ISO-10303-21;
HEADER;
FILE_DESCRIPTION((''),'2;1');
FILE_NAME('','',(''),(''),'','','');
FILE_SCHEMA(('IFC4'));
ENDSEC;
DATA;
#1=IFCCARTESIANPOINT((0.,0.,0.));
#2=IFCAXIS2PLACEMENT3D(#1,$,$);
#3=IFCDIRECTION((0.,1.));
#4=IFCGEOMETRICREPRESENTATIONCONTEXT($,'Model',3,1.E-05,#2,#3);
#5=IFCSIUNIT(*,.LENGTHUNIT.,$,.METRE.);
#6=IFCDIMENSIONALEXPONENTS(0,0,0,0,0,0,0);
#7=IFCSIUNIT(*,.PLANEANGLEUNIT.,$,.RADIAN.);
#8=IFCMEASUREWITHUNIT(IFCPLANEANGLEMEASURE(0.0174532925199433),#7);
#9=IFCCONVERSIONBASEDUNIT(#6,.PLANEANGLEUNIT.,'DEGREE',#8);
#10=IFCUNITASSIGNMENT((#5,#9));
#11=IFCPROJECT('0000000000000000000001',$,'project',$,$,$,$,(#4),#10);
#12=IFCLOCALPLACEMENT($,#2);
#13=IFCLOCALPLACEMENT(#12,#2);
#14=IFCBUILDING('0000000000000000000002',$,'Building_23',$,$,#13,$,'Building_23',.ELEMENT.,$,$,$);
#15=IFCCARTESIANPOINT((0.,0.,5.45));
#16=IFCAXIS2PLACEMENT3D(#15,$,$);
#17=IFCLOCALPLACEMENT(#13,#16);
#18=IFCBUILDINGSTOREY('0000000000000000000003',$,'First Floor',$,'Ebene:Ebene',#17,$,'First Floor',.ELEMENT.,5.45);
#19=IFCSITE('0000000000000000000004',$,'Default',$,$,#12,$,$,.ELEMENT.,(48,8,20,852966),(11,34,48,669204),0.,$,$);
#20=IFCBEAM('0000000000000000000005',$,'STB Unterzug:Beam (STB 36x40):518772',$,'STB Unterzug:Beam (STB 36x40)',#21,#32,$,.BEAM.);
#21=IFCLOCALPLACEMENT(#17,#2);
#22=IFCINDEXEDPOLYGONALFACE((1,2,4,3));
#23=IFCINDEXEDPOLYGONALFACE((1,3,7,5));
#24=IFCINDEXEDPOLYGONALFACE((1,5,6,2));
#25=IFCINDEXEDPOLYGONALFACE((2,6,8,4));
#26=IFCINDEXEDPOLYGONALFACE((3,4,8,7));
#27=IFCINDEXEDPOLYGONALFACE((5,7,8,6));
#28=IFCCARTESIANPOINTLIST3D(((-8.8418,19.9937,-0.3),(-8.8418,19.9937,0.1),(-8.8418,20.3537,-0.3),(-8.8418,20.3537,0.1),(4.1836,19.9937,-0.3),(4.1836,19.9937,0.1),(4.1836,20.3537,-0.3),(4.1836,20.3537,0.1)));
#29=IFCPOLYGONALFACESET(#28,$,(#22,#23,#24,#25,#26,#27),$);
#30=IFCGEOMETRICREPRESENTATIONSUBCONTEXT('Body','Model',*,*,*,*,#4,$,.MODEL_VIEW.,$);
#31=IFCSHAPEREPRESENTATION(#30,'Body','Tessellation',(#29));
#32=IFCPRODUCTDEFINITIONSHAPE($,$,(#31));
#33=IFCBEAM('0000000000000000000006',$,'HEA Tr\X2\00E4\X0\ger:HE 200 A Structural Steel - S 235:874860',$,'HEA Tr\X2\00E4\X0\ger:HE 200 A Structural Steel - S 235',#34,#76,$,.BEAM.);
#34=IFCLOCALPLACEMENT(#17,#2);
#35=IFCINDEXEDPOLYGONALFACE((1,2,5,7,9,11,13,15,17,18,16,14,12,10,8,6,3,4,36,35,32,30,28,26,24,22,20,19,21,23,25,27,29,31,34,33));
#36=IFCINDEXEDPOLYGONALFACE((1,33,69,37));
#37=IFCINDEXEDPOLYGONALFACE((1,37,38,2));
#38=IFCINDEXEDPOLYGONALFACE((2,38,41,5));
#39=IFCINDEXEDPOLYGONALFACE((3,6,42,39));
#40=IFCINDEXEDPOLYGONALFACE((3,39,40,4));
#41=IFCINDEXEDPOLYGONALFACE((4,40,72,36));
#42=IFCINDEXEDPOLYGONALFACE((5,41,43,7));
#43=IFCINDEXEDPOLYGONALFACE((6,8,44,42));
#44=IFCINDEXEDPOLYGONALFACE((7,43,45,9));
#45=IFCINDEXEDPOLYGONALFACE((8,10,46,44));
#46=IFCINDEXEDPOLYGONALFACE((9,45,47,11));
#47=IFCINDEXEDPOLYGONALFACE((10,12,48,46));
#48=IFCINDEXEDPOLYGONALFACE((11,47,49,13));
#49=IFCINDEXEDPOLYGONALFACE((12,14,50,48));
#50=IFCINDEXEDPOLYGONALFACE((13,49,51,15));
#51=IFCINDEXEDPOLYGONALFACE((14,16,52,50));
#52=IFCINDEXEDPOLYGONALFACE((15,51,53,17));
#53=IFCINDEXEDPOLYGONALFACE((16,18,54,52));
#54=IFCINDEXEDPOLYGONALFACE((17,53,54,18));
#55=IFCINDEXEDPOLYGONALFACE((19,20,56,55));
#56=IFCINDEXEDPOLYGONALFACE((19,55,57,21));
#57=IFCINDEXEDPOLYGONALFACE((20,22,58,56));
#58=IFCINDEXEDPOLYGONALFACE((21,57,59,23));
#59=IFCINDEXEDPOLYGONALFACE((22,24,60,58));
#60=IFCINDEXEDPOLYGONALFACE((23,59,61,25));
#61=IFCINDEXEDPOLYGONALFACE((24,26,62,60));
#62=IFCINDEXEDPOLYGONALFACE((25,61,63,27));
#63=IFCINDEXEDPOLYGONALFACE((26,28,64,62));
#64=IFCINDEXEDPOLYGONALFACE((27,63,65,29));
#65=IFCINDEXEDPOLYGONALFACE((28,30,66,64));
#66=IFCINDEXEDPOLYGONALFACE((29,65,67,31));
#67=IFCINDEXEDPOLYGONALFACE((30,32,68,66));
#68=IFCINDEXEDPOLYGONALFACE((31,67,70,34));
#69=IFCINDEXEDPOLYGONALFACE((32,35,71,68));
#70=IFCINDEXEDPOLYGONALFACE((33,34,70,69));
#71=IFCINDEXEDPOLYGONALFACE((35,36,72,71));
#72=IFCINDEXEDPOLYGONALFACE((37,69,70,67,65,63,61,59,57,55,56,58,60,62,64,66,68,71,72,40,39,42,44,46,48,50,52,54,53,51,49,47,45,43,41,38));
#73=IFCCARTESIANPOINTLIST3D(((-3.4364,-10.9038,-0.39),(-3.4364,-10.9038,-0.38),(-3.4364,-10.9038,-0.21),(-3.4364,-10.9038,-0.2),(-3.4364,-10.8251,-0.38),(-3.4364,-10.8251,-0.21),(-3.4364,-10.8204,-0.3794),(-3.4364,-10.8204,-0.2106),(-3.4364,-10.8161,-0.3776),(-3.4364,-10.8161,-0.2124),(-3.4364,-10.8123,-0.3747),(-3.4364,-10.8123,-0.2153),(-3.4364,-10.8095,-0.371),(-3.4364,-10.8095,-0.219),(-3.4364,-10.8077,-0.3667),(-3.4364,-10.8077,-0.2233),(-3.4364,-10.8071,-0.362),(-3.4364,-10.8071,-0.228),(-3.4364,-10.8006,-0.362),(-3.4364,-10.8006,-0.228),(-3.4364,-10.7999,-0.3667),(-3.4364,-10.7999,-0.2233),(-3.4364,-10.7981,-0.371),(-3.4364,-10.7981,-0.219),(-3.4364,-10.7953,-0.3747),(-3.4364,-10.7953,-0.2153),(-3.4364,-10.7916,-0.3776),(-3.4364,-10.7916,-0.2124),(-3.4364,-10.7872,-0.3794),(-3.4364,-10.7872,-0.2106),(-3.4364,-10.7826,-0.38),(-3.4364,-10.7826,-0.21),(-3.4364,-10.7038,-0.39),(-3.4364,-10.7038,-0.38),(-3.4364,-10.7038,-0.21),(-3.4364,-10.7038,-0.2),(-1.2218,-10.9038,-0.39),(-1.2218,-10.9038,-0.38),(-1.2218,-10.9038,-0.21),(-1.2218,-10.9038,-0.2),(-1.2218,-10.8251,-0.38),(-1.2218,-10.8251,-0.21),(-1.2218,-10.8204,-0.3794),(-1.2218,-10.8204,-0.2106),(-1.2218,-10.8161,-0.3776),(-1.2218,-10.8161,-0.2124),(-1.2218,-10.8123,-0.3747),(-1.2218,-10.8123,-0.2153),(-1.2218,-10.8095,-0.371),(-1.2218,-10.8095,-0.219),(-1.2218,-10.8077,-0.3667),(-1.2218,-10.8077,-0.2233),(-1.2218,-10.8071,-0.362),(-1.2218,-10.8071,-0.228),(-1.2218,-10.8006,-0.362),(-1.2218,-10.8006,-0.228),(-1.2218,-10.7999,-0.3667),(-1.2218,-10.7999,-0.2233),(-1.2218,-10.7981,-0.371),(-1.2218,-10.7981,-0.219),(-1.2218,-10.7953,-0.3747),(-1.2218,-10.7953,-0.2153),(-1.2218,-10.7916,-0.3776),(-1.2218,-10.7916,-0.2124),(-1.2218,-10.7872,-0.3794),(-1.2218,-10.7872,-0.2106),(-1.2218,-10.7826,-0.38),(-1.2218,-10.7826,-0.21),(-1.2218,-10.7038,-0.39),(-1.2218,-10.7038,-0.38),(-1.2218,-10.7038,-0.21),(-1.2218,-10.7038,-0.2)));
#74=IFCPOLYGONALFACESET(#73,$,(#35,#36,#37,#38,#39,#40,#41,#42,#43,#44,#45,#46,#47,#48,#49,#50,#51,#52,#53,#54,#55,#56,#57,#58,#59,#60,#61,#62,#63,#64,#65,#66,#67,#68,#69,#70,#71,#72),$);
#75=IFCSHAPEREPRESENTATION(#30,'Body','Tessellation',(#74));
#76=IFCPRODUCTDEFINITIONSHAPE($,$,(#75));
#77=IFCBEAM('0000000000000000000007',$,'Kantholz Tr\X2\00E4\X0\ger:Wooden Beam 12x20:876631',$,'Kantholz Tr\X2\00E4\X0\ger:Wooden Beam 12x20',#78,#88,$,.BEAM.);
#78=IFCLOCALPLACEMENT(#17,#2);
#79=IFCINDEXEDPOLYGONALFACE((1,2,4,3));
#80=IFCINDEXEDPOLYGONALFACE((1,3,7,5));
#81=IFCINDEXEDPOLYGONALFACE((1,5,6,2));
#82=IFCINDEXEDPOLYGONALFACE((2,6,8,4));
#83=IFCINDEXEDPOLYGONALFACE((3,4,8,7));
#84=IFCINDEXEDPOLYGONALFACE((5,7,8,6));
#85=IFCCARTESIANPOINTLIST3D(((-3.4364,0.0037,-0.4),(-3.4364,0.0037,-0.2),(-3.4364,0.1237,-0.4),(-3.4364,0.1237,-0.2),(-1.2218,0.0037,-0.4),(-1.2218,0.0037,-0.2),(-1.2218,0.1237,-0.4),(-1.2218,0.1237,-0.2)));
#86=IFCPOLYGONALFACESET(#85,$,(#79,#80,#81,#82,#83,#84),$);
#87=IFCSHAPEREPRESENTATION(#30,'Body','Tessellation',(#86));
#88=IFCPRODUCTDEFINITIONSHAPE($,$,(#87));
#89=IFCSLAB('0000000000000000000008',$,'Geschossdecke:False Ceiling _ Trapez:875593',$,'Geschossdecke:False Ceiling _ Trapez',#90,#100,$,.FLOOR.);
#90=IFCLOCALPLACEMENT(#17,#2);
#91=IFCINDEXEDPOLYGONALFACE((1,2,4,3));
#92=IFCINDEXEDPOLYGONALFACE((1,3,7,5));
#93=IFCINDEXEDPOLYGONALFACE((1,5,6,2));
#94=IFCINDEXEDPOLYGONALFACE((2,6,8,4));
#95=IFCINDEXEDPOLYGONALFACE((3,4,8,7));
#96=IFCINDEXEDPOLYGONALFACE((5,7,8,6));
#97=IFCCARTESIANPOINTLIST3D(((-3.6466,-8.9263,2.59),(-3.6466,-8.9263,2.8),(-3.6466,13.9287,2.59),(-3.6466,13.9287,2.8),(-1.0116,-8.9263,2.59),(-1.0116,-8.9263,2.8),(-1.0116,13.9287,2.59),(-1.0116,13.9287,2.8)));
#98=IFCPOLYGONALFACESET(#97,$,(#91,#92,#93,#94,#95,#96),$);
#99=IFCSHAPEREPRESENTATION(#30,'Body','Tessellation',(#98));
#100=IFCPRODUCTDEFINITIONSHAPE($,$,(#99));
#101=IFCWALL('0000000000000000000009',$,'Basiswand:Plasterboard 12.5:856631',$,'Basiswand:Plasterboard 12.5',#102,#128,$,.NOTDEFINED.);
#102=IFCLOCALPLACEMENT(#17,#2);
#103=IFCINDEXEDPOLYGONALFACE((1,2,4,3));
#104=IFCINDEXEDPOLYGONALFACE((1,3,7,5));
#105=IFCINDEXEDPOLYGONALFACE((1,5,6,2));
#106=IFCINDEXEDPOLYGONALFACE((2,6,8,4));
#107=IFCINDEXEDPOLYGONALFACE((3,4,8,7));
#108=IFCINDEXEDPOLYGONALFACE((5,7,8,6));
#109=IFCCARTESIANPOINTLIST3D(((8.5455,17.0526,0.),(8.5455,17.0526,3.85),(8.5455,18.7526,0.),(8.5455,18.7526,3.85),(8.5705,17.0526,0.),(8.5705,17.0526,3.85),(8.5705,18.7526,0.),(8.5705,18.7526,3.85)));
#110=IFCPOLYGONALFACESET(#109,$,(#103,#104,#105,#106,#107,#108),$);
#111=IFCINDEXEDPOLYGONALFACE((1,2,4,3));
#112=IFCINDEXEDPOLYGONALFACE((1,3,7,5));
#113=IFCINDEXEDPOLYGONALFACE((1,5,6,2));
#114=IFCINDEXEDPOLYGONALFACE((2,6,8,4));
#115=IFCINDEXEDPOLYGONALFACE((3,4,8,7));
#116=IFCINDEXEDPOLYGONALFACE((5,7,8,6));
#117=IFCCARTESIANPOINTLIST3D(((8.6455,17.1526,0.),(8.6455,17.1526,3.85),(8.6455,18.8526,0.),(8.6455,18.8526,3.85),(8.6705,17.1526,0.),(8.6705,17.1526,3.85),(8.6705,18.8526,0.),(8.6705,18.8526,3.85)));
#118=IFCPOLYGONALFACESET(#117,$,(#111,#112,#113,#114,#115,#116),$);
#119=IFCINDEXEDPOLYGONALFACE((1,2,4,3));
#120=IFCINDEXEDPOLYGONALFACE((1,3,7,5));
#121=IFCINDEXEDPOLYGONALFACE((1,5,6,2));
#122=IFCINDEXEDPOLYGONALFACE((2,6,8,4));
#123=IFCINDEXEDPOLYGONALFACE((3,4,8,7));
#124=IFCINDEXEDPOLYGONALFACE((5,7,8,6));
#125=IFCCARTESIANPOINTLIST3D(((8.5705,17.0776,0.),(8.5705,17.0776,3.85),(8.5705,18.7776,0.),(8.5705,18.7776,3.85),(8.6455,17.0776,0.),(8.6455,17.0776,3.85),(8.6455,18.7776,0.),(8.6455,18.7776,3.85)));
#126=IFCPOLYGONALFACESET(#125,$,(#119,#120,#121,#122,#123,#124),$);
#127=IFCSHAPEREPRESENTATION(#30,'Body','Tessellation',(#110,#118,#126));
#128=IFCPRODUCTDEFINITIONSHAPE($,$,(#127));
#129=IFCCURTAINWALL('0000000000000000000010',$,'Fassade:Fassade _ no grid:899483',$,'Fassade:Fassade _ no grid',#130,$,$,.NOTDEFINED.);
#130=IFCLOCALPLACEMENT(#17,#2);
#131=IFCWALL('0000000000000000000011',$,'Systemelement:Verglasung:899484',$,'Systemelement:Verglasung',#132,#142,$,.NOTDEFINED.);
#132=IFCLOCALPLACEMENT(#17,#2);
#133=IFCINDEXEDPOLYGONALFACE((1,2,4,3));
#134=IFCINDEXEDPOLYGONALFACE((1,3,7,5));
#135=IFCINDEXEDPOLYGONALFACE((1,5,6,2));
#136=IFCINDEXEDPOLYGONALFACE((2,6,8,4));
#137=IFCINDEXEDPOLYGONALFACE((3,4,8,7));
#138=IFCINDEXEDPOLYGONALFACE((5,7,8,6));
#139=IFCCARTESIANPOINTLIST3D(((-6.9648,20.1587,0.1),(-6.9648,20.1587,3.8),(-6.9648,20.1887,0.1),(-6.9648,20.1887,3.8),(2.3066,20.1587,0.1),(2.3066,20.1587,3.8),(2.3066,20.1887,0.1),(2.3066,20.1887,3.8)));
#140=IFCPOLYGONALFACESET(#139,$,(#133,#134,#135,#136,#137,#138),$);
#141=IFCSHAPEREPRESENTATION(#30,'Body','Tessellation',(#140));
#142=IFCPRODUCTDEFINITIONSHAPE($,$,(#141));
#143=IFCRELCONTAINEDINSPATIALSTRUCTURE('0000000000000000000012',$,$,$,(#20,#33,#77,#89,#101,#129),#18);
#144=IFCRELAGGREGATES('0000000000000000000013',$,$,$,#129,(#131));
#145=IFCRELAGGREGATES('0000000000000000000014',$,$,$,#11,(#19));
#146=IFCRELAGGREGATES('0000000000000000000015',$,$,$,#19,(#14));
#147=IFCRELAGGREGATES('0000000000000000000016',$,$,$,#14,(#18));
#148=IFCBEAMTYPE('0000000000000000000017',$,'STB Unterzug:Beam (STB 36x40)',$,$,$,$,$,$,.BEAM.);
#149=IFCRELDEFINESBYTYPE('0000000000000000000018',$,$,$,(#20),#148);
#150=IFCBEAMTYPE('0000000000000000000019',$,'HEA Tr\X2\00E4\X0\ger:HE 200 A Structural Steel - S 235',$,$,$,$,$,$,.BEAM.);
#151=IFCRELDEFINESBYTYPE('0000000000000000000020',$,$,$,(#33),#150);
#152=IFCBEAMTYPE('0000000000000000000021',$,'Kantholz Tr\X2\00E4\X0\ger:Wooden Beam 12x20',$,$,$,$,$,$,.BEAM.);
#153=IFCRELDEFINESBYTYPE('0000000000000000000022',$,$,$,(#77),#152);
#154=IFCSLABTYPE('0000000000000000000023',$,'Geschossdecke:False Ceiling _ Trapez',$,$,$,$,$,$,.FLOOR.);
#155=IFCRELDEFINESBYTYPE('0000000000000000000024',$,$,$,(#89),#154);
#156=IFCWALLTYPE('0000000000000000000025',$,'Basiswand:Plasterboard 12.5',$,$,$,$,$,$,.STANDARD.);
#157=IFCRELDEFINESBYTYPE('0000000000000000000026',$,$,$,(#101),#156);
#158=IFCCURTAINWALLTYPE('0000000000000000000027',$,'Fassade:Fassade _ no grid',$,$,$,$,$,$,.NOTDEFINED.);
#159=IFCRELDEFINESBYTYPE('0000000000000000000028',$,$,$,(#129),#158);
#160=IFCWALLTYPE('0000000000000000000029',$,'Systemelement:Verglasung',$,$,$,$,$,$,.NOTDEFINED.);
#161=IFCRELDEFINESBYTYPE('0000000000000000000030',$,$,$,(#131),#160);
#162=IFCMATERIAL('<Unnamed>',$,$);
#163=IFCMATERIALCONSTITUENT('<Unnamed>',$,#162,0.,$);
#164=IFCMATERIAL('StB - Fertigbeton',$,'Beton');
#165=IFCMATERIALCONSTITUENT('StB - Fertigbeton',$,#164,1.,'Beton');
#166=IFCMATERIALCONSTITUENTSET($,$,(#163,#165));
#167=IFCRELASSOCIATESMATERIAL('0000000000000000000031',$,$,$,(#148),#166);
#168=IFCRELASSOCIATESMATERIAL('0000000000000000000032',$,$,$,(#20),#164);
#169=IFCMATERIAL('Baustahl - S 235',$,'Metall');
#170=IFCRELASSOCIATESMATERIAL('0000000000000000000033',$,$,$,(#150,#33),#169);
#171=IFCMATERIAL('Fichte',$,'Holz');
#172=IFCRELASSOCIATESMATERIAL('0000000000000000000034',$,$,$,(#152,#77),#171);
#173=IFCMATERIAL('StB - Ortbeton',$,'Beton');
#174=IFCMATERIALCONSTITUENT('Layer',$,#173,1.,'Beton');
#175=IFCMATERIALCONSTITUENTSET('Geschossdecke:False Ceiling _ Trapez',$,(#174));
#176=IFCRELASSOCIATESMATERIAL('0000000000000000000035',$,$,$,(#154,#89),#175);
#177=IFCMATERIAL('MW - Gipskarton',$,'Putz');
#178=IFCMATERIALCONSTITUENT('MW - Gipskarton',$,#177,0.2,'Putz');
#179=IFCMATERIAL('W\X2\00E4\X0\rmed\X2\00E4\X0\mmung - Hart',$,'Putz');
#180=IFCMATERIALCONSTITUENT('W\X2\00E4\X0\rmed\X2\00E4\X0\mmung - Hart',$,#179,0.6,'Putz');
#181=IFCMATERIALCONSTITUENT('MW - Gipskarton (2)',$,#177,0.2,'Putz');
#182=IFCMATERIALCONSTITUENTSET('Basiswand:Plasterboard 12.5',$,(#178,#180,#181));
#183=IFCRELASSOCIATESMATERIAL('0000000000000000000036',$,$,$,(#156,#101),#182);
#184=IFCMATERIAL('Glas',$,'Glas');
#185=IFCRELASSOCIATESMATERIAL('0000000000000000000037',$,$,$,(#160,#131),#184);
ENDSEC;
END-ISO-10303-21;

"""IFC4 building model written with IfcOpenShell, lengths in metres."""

from ifc_helpers import new_model, entity, si_unit, converted_unit, direction, frame, origin, place, context, subcontext, project, spatial, line, arc, indexed_curve, outline, extrude, source, transform, mapped, material, constituent, constituent_set, type_object, type_shapes, element, aggregate, save


model = new_model("IFC4")

# Units and contexts
model_context = context("Model", 3, precision=1e-05, world=origin(), true_north=direction((0.0, 1.0)))
body_context = subcontext(model_context, "Body", "Model", "MODEL_VIEW")
ifc_project = project(units=[si_unit("LENGTHUNIT", "METRE"), converted_unit("PLANEANGLEUNIT", "DEGREE", entity("IfcPlaneAngleMeasure", 0.0174532925199433), si_unit("PLANEANGLEUNIT", "RADIAN"), dimensions=[0, 0, 0, 0, 0, 0, 0])], contexts=[model_context])

# Site, building, storey
site_placement = place(None, origin())
site = spatial("IfcSite", under=ifc_project, at=site_placement, Name="Default", CompositionType="ELEMENT", RefLatitude=(48, 8, 20, 852966), RefLongitude=(11, 34, 48, 669204), RefElevation=0.0)
building_placement = place(site_placement, origin())
building = spatial("IfcBuilding", under=site, at=building_placement, Name="Building_23", LongName="Building_23", CompositionType="ELEMENT")
storey_placement = place(building_placement, frame((0.0, 0.0, 5.45)))
storey = spatial("IfcBuildingStorey", under=building, at=storey_placement, Name="First Floor", ObjectType="Ebene:Ebene", LongName="First Floor", CompositionType="ELEMENT", Elevation=5.45)

# Beams
ifc_material_1 = material(Name="StB - Fertigbeton", Category="Beton")
ifc_material_2 = material(Name="<Unnamed>")
ifc_constituent_1 = constituent(ifc_material_2, Name="<Unnamed>", fraction=0.0)
ifc_constituent_2 = constituent(ifc_material_1, Name="StB - Fertigbeton", Category="Beton", fraction=1.0)
ifc_constituent_set_1 = constituent_set(constituents=[ifc_constituent_1, ifc_constituent_2])
beam_type_1 = type_object("IfcBeamType", Name="STB Unterzug:Beam (STB 36x40)", PredefinedType="BEAM", material=ifc_constituent_set_1)
shared_shape_1 = source(origin(), body_context, "Body", "SweptSolid", [
    extrude(outline(indexed_curve([(-0.2, -0.18), (0.2, -0.18), (0.2, 0.18), (-0.2, 0.18), (-0.2, -0.18)], self_intersect=False)), frame((-8.8418, 20.1737, 5.35), z_axis=(1.0, 0.0, 0.0), x_axis=(0.0, 0.0, -1.0)), (0.0, 0.0, 1.0), 13.0254),
])
type_shapes(beam_type_1, [shared_shape_1])
beam_1_placement = place(storey_placement, frame((0.0, 0.0, -5.45)))
element("IfcBeam", 1, at=beam_1_placement, inside=storey, type_object=beam_type_1, material=ifc_material_1, Name="STB Unterzug:Beam (STB 36x40):518772", ObjectType="STB Unterzug:Beam (STB 36x40)", PredefinedType="BEAM", context=body_context, shape_type="MappedRepresentation", body=[
    mapped(shared_shape_1, transform((0.0, 0.0, 0.0), scale=1.0)),
])
ifc_material_3 = material(Name="Baustahl - S 235", Category="Metall")
beam_type_2 = type_object("IfcBeamType", Name="HEA Träger:HE 200 A Structural Steel - S 235", PredefinedType="BEAM", material=ifc_material_3)
shared_shape_2 = source(origin(), body_context, "Body", "SweptSolid", [
    extrude(outline(indexed_curve([(-0.1, -0.085), (-0.1, -0.095), (0.1, -0.095), (0.1, -0.085), (0.0213, -0.085), (0.0085, -0.0797), (0.0033, -0.067), (0.0033, 0.067), (0.0085, 0.0797), (0.0213, 0.085), (0.1, 0.085), (0.1, 0.095), (-0.1, 0.095), (-0.1, 0.085), (-0.0213, 0.085), (-0.0085, 0.0797), (-0.0033, 0.067), (-0.0033, -0.067), (-0.0085, -0.0797), (-0.0213, -0.085)], segments=[line(1, 2, 3, 4, 5), arc(5, 6, 7), line(7, 8), arc(8, 9, 10), line(10, 11, 12, 13, 14, 15), arc(15, 16, 17), line(17, 18), arc(18, 19, 20), line(20, 1)], self_intersect=False)), frame((-1.1073, 0.0, 0.0), z_axis=(-1.0, 0.0, 0.0), x_axis=(0.0, -1.0, 0.0)), (0.0, 0.0, -1.0), 2.2146),
])
type_shapes(beam_type_2, [shared_shape_2])
beam_2_placement = place(storey_placement, frame((-2.3291, -10.8038, -0.295), z_axis=(0.0, 0.0, 1.0), x_axis=(-1.0, 0.0, 0.0)))
element("IfcBeam", 2, at=beam_2_placement, inside=storey, type_object=beam_type_2, material=ifc_material_3, Name="HEA Träger:HE 200 A Structural Steel - S 235:874860", ObjectType="HEA Träger:HE 200 A Structural Steel - S 235", PredefinedType="BEAM", context=body_context, shape_type="MappedRepresentation", body=[
    mapped(shared_shape_2, transform((0.0, 0.0, 0.0), scale=1.0)),
])
ifc_material_4 = material(Name="Fichte", Category="Holz")
beam_type_3 = type_object("IfcBeamType", Name="Kantholz Träger:Wooden Beam 12x20", PredefinedType="BEAM", material=ifc_material_4)
shared_shape_3 = source(origin(), body_context, "Body", "SweptSolid", [
    extrude(outline(indexed_curve([(-0.1, -0.06), (0.1, -0.06), (0.1, 0.06), (-0.1, 0.06), (-0.1, -0.06)], self_intersect=False)), frame((-1.2218, 0.0637, 5.15), z_axis=(-1.0, 0.0, 0.0), x_axis=(0.0, 0.0, -1.0)), (0.0, 0.0, 1.0), 2.2146),
])
type_shapes(beam_type_3, [shared_shape_3])
beam_3_placement = place(storey_placement, frame((0.0, 0.0, -5.45)))
element("IfcBeam", 3, at=beam_3_placement, inside=storey, type_object=beam_type_3, material=ifc_material_4, Name="Kantholz Träger:Wooden Beam 12x20:876631", ObjectType="Kantholz Träger:Wooden Beam 12x20", PredefinedType="BEAM", context=body_context, shape_type="MappedRepresentation", body=[
    mapped(shared_shape_3, transform((0.0, 0.0, 0.0), scale=1.0)),
])

# Slab
ifc_material_5 = material(Name="StB - Ortbeton", Category="Beton")
ifc_constituent_3 = constituent(ifc_material_5, Name="Layer", Category="Beton", fraction=1.0)
ifc_constituent_set_2 = constituent_set(constituents=[ifc_constituent_3], Name="Geschossdecke:False Ceiling _ Trapez")
slab_type_1 = type_object("IfcSlabType", Name="Geschossdecke:False Ceiling _ Trapez", PredefinedType="FLOOR", material=ifc_constituent_set_2)
slab_1_placement = place(storey_placement, origin())
element("IfcSlab", 4, at=slab_1_placement, inside=storey, type_object=slab_type_1, material=ifc_constituent_set_2, Name="Geschossdecke:False Ceiling _ Trapez:875593", ObjectType="Geschossdecke:False Ceiling _ Trapez", PredefinedType="FLOOR", context=body_context, shape_type="SweptSolid", body=[
    extrude(outline(indexed_curve([(-11.4275, -1.3175), (11.4275, -1.3175), (11.4275, 1.3175), (-11.4275, 1.3175), (-11.4275, -1.3175)], self_intersect=False)), frame((-2.3291, 2.5012, 2.8), z_axis=(0.0, 0.0, -1.0), x_axis=(0.0, 1.0, 0.0)), (0.0, 0.0, 1.0), 0.21),
])

# Shared definitions
ifc_material_6 = material(Name="MW - Gipskarton", Category="Putz")
ifc_constituent_4 = constituent(ifc_material_6, Name="MW - Gipskarton", Category="Putz", fraction=0.2)
ifc_material_7 = material(Name="Wärmedämmung - Hart", Category="Putz")
ifc_constituent_5 = constituent(ifc_material_7, Name="Wärmedämmung - Hart", Category="Putz", fraction=0.6)
ifc_constituent_6 = constituent(ifc_material_6, Name="MW - Gipskarton (2)", Category="Putz", fraction=0.2)
ifc_constituent_set_3 = constituent_set(constituents=[ifc_constituent_4, ifc_constituent_5, ifc_constituent_6], Name="Basiswand:Plasterboard 12.5")
wall_type_1 = type_object("IfcWallType", Name="Basiswand:Plasterboard 12.5", PredefinedType="STANDARD", material=ifc_constituent_set_3)

# Wall
wall_1_placement = place(storey_placement, frame((8.608, 18.7526, 0.0), z_axis=(0.0, 0.0, 1.0), x_axis=(0.0, -1.0, 0.0)))
element("IfcWall", 5, at=wall_1_placement, inside=storey, type_object=wall_type_1, material=ifc_constituent_set_3, Name="Basiswand:Plasterboard 12.5:856631", ObjectType="Basiswand:Plasterboard 12.5", PredefinedType="NOTDEFINED", context=body_context, shape_type="SweptSolid", body=[
    extrude(outline(indexed_curve([(-1.925, -0.85), (1.925, -0.85), (1.925, 0.85), (-1.925, 0.85), (-1.925, -0.85)], self_intersect=False)), frame((0.85, -0.0625, 1.925), z_axis=(0.0, 1.0, 0.0), x_axis=(0.0, 0.0, 1.0)), (0.0, 0.0, 1.0), 0.025),
    extrude(outline(indexed_curve([(-1.925, -0.85), (1.925, -0.85), (1.925, 0.85), (-1.925, 0.85), (-1.925, -0.85)], self_intersect=False)), frame((0.75, 0.0375, 1.925), z_axis=(0.0, 1.0, 0.0), x_axis=(0.0, 0.0, 1.0)), (0.0, 0.0, 1.0), 0.025),
    extrude(outline(indexed_curve([(-1.925, -0.85), (1.925, -0.85), (1.925, 0.85), (-1.925, 0.85), (-1.925, -0.85)], self_intersect=False)), frame((0.825, -0.0375, 1.925), z_axis=(0.0, 1.0, 0.0), x_axis=(0.0, 0.0, 1.0)), (0.0, 0.0, 1.0), 0.075),
])

# Curtain wall, wall
curtain_wall_type = type_object("IfcCurtainWallType", Name="Fassade:Fassade _ no grid", PredefinedType="NOTDEFINED")
curtain_wall_placement = place(storey_placement, frame((0.0, 0.0, -5.45)))
curtain_wall = element("IfcCurtainWall", 6, at=curtain_wall_placement, inside=storey, type_object=curtain_wall_type, Name="Fassade:Fassade _ no grid:899483", ObjectType="Fassade:Fassade _ no grid", PredefinedType="NOTDEFINED")
ifc_material_8 = material(Name="Glas", Category="Glas")
wall_type_2 = type_object("IfcWallType", Name="Systemelement:Verglasung", PredefinedType="NOTDEFINED", material=ifc_material_8)
shared_shape_4 = source(origin(), body_context, "Body", "SweptSolid", [
    extrude(outline(indexed_curve([(-0.015, -4.6357), (0.015, -4.6357), (0.015, 4.6357), (-0.015, 4.6357), (-0.015, -4.6357)], self_intersect=False)), frame((0.0, 0.0, 0.0), z_axis=(0.0, 0.0, 1.0), x_axis=(0.0, 1.0, 0.0)), (0.0, 0.0, 1.0), 3.7),
])
type_shapes(wall_type_2, [shared_shape_4])
wall_2_placement = place(storey_placement, frame((-2.3291, 20.1737, 0.1)))
wall_2 = element("IfcWall", 7, at=wall_2_placement, type_object=wall_type_2, material=ifc_material_8, Name="Systemelement:Verglasung:899484", ObjectType="Systemelement:Verglasung", PredefinedType="NOTDEFINED", context=body_context, shape_type="MappedRepresentation", body=[
    mapped(shared_shape_4, transform((0.0, 0.0, 0.0), scale=1.0)),
])
aggregate(curtain_wall, [wall_2])

save(model, "model.ifc")
